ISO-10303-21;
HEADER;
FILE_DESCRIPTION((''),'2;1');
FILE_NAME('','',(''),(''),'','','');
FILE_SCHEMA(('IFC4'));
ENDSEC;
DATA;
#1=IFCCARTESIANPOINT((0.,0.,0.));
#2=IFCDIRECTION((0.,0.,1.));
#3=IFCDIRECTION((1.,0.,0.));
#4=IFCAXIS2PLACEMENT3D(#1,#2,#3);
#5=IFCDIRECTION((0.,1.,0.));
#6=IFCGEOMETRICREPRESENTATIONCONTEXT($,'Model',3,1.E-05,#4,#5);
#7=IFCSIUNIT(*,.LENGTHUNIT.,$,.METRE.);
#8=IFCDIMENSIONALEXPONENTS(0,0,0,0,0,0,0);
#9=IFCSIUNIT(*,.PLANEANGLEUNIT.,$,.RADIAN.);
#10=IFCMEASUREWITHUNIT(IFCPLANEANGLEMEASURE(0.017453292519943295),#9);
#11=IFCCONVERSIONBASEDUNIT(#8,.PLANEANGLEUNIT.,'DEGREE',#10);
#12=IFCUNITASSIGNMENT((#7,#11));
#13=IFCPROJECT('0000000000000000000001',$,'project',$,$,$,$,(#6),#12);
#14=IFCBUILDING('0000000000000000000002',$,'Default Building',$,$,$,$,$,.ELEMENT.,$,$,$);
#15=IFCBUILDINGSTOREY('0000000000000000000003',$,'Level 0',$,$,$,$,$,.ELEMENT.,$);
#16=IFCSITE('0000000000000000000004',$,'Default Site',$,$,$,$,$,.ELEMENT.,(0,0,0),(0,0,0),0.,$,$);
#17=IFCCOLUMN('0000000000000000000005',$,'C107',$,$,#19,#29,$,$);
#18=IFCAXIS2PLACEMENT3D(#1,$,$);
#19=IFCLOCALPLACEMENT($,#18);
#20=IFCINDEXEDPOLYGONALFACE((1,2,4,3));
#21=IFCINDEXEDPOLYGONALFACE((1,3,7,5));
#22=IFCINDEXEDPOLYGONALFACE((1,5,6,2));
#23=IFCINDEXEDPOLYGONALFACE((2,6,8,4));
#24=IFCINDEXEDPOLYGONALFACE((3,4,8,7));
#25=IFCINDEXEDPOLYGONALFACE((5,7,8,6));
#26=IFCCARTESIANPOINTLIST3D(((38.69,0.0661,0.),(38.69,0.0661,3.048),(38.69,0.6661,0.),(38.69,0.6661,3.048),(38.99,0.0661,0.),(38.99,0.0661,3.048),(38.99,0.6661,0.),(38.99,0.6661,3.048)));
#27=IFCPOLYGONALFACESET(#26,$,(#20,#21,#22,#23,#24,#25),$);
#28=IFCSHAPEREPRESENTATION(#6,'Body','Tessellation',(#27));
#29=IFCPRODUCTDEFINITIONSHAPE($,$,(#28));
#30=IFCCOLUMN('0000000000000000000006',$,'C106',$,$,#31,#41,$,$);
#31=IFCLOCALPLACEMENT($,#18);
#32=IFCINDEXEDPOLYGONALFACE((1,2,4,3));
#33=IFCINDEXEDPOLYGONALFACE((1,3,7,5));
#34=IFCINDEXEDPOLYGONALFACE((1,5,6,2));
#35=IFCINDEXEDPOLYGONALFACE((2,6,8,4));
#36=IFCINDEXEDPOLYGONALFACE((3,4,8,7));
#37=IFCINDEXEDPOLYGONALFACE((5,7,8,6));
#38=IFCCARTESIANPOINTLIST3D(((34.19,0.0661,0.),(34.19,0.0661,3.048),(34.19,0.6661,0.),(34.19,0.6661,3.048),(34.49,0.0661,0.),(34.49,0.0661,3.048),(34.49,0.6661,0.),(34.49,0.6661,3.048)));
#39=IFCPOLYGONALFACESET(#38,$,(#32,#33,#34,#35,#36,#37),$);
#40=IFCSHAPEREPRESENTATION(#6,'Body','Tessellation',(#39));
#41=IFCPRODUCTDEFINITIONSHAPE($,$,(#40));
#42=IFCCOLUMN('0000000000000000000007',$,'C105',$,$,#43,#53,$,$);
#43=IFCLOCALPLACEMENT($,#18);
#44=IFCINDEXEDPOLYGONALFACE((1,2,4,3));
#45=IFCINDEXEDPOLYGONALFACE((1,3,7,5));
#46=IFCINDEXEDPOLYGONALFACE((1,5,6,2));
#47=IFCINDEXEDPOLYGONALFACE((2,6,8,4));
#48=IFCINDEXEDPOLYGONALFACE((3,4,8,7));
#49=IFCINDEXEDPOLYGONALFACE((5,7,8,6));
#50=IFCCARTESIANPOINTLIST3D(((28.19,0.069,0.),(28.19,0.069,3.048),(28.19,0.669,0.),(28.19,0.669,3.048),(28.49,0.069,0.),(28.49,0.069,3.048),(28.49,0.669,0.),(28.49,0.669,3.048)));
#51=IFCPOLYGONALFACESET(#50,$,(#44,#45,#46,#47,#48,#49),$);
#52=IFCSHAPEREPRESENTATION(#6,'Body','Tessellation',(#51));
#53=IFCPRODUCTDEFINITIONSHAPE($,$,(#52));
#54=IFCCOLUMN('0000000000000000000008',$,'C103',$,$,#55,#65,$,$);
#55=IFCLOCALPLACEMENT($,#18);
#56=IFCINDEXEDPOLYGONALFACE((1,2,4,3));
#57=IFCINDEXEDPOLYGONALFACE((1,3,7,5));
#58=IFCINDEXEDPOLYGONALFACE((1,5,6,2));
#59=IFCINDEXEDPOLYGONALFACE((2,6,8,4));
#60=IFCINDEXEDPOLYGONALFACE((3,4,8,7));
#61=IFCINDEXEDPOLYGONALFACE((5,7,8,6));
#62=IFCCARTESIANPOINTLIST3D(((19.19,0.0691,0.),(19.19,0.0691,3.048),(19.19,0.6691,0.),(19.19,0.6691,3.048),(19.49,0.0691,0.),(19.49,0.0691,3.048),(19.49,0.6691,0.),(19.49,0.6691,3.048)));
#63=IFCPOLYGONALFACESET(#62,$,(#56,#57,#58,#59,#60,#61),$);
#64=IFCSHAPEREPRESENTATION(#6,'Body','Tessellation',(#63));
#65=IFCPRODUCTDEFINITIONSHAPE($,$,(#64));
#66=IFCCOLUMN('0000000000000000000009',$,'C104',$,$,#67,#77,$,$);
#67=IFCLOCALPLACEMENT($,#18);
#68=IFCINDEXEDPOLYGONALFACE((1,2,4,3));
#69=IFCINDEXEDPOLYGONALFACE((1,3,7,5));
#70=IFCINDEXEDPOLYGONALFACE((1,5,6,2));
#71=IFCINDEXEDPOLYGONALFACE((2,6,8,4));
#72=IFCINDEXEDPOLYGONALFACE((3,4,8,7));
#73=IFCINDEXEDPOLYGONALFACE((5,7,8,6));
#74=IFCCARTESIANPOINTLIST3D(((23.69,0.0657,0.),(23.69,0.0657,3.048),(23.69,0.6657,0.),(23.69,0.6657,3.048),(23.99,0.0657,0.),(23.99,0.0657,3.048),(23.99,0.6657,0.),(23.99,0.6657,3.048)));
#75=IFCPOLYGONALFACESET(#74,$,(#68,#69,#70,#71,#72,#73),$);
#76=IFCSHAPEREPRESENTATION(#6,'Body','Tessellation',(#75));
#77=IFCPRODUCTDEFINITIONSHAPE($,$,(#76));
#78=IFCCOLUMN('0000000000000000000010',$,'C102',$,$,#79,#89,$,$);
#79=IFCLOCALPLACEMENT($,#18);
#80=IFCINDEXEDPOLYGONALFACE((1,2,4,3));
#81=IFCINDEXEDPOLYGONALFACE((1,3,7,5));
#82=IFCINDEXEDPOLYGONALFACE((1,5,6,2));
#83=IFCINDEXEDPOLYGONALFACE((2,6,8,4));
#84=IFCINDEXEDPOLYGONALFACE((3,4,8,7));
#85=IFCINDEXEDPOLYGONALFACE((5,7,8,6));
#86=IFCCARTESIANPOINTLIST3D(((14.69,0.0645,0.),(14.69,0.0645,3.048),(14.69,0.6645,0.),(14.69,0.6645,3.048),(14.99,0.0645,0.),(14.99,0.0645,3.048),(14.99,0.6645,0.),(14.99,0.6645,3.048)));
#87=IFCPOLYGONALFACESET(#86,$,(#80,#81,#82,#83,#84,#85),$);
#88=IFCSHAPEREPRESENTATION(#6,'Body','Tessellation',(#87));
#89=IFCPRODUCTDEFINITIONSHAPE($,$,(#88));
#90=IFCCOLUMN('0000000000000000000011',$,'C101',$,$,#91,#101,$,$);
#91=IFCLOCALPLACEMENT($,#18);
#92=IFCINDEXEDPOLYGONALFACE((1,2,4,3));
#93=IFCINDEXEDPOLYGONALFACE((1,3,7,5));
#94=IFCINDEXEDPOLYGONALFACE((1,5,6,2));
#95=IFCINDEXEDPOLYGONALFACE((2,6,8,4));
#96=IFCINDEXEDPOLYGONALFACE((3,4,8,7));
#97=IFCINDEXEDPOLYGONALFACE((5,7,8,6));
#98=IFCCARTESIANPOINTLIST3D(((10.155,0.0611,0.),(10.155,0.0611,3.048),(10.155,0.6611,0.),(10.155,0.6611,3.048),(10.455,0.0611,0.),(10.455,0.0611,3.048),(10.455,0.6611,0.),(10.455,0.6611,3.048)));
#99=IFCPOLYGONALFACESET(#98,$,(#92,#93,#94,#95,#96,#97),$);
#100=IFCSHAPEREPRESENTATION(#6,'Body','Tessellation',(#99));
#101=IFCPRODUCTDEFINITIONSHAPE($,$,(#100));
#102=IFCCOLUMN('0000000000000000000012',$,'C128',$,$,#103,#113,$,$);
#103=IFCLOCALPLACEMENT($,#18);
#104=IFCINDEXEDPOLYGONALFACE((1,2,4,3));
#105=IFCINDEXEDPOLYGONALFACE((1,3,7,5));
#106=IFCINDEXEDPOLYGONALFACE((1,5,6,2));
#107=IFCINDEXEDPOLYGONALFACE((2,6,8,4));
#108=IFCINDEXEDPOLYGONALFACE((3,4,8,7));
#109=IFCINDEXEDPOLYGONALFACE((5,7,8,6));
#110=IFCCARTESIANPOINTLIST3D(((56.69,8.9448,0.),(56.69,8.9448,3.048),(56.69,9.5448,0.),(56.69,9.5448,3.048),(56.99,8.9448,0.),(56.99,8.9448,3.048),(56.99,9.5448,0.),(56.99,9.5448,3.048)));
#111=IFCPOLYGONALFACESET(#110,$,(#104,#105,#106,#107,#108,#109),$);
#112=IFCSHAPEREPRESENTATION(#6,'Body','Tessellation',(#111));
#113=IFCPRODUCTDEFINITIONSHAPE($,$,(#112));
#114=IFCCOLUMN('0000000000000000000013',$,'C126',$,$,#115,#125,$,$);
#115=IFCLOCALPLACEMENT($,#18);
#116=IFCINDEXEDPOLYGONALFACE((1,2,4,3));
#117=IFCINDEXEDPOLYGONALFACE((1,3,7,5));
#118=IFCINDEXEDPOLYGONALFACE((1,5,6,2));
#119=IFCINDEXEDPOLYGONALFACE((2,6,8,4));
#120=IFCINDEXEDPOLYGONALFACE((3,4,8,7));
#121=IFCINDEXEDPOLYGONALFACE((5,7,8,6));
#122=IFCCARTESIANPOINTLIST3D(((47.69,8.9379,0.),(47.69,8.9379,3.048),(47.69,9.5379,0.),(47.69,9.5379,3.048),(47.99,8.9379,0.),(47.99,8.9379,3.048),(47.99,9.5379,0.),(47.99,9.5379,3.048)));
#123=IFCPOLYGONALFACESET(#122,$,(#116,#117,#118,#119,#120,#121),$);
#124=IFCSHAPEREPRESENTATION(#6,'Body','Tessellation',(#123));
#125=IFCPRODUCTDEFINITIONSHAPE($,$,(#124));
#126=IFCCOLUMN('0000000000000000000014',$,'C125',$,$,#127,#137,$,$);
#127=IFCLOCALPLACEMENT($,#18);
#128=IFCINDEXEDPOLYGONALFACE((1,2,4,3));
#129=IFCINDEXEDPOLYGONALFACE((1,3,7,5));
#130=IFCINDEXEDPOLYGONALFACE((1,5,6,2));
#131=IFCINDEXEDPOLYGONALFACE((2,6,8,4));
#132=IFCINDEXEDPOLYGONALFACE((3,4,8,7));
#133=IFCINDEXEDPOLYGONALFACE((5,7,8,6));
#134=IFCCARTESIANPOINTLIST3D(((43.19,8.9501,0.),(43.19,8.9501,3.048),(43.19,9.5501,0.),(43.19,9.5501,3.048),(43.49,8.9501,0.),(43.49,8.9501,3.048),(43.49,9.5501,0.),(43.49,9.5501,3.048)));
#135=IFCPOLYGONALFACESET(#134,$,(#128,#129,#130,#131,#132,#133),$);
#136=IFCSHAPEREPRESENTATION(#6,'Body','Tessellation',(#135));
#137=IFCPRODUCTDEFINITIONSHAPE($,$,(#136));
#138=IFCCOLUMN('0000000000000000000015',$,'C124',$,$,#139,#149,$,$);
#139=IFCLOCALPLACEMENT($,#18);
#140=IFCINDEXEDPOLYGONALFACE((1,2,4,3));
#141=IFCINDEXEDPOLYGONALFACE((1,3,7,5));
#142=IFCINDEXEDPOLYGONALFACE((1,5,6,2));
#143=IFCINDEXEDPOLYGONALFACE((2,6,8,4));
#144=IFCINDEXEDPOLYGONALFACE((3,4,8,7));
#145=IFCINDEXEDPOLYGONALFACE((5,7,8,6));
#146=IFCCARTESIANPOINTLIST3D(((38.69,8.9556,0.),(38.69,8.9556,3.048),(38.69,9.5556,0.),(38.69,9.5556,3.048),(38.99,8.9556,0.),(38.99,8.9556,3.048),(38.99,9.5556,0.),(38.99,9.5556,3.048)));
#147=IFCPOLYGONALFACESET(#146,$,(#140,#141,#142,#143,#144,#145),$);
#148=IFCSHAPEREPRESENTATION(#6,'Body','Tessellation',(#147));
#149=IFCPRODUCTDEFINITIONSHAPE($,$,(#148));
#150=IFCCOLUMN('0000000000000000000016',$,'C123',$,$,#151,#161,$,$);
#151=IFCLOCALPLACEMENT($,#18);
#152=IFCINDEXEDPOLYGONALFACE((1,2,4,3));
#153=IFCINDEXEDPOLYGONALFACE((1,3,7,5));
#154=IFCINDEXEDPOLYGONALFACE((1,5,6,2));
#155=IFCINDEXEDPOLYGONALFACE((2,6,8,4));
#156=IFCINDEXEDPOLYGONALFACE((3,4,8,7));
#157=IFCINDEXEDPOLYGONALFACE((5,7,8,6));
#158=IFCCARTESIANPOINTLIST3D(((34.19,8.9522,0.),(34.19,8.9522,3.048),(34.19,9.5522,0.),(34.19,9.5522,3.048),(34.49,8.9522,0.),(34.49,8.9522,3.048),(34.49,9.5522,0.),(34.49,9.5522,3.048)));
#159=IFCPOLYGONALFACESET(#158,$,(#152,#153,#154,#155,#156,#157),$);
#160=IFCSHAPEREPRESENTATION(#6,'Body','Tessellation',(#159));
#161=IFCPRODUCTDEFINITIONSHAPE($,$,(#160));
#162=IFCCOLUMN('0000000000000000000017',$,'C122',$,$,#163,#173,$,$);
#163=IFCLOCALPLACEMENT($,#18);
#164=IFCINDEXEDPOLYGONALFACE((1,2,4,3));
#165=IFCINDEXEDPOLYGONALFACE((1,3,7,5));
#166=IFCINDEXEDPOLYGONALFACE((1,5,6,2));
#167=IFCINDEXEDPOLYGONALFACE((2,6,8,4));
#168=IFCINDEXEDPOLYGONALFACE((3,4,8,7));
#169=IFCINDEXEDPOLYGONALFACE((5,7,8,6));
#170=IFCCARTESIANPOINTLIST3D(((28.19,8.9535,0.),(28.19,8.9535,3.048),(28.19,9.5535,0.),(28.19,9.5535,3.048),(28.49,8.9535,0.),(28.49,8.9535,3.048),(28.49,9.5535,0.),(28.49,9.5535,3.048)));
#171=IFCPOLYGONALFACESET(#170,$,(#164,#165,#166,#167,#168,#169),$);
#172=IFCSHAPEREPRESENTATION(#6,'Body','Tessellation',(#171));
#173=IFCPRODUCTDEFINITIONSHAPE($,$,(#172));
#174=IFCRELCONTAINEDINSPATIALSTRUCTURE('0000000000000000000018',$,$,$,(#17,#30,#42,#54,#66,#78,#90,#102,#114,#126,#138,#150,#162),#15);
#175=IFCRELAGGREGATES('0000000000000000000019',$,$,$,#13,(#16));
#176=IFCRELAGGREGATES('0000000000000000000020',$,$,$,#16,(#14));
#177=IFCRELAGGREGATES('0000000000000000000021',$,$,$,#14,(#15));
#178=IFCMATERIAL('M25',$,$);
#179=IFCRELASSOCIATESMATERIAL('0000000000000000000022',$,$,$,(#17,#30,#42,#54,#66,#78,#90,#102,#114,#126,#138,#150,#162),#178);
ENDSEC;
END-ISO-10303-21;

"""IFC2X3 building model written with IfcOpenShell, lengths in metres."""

from ifc_helpers import new_model, entity, si_unit, converted_unit, direction, frame, frame_2d, origin_with_axes, place, context, project, spatial, rectangle, extrude, material, element, save


model = new_model("IFC2X3")

# Units and contexts
model_context = context("Model", 3, precision=1e-05, world=origin_with_axes(), true_north=direction((0.0, 1.0, 0.0)))
ifc_project = project(units=[si_unit("LENGTHUNIT", "METRE"), converted_unit("PLANEANGLEUNIT", "DEGREE", entity("IfcPlaneAngleMeasure", 0.017453292519943295), si_unit("PLANEANGLEUNIT", "RADIAN"), dimensions=[0, 0, 0, 0, 0, 0, 0])], contexts=[model_context])

# Site, building, storey
site = spatial("IfcSite", under=ifc_project, Name="Default Site", CompositionType="ELEMENT", RefLatitude=(0, 0, 0), RefLongitude=(0, 0, 0), RefElevation=0.0)
building = spatial("IfcBuilding", under=site, Name="Default Building", CompositionType="ELEMENT")
storey = spatial("IfcBuildingStorey", under=building, Name="Level 0", CompositionType="ELEMENT")

# Columns
ifc_material = material(Name="M25")
placement = place(None, origin_with_axes())
element("IfcColumn", 1, at=placement, inside=storey, material=ifc_material, Name="C107", context=model_context, shape_type="SweptSolid", body=[
    extrude(rectangle(XDim=0.3, YDim=0.6, at=frame_2d((0.0, 0.0), x_axis=(1.0, 0.0, 0.0))), frame((38.84, 0.3661, 0.0), z_axis=(0.0, 0.0, 1.0), x_axis=(1.0, 0.0, 0.0)), (0.0, 0.0, 1.0), 3.048),
])
element("IfcColumn", 2, at=placement, inside=storey, material=ifc_material, Name="C106", context=model_context, shape_type="SweptSolid", body=[
    extrude(rectangle(XDim=0.3, YDim=0.6, at=frame_2d((0.0, 0.0), x_axis=(1.0, 0.0, 0.0))), frame((34.34, 0.3661, 0.0), z_axis=(0.0, 0.0, 1.0), x_axis=(1.0, 0.0, 0.0)), (0.0, 0.0, 1.0), 3.048),
])
element("IfcColumn", 3, at=placement, inside=storey, material=ifc_material, Name="C105", context=model_context, shape_type="SweptSolid", body=[
    extrude(rectangle(XDim=0.3, YDim=0.6, at=frame_2d((0.0, 0.0), x_axis=(1.0, 0.0, 0.0))), frame((28.34, 0.369, 0.0), z_axis=(0.0, 0.0, 1.0), x_axis=(1.0, 0.0, 0.0)), (0.0, 0.0, 1.0), 3.048),
])
element("IfcColumn", 4, at=placement, inside=storey, material=ifc_material, Name="C103", context=model_context, shape_type="SweptSolid", body=[
    extrude(rectangle(XDim=0.3, YDim=0.6, at=frame_2d((0.0, 0.0), x_axis=(1.0, 0.0, 0.0))), frame((19.34, 0.3691, 0.0), z_axis=(0.0, 0.0, 1.0), x_axis=(1.0, 0.0, 0.0)), (0.0, 0.0, 1.0), 3.048),
])
element("IfcColumn", 5, at=placement, inside=storey, material=ifc_material, Name="C104", context=model_context, shape_type="SweptSolid", body=[
    extrude(rectangle(XDim=0.3, YDim=0.6, at=frame_2d((0.0, 0.0), x_axis=(1.0, 0.0, 0.0))), frame((23.84, 0.3657, 0.0), z_axis=(0.0, 0.0, 1.0), x_axis=(1.0, 0.0, 0.0)), (0.0, 0.0, 1.0), 3.048),
])
element("IfcColumn", 6, at=placement, inside=storey, material=ifc_material, Name="C102", context=model_context, shape_type="SweptSolid", body=[
    extrude(rectangle(XDim=0.3, YDim=0.6, at=frame_2d((0.0, 0.0), x_axis=(1.0, 0.0, 0.0))), frame((14.84, 0.3645, 0.0), z_axis=(0.0, 0.0, 1.0), x_axis=(1.0, 0.0, 0.0)), (0.0, 0.0, 1.0), 3.048),
])
element("IfcColumn", 7, at=placement, inside=storey, material=ifc_material, Name="C101", context=model_context, shape_type="SweptSolid", body=[
    extrude(rectangle(XDim=0.3, YDim=0.6, at=frame_2d((0.0, 0.0), x_axis=(1.0, 0.0, 0.0))), frame((10.305, 0.3611, 0.0), z_axis=(0.0, 0.0, 1.0), x_axis=(1.0, 0.0, 0.0)), (0.0, 0.0, 1.0), 3.048),
])
element("IfcColumn", 8, at=placement, inside=storey, material=ifc_material, Name="C128", context=model_context, shape_type="SweptSolid", body=[
    extrude(rectangle(XDim=0.3, YDim=0.6, at=frame_2d((0.0, 0.0), x_axis=(1.0, 0.0, 0.0))), frame((56.84, 9.2448, 0.0), z_axis=(0.0, 0.0, 1.0), x_axis=(1.0, 0.0, 0.0)), (0.0, 0.0, 1.0), 3.048),
])
element("IfcColumn", 9, at=placement, inside=storey, material=ifc_material, Name="C126", context=model_context, shape_type="SweptSolid", body=[
    extrude(rectangle(XDim=0.3, YDim=0.6, at=frame_2d((0.0, 0.0), x_axis=(1.0, 0.0, 0.0))), frame((47.84, 9.2379, 0.0), z_axis=(0.0, 0.0, 1.0), x_axis=(1.0, 0.0, 0.0)), (0.0, 0.0, 1.0), 3.048),
])
element("IfcColumn", 10, at=placement, inside=storey, material=ifc_material, Name="C125", context=model_context, shape_type="SweptSolid", body=[
    extrude(rectangle(XDim=0.3, YDim=0.6, at=frame_2d((0.0, 0.0), x_axis=(1.0, 0.0, 0.0))), frame((43.34, 9.2501, 0.0), z_axis=(0.0, 0.0, 1.0), x_axis=(1.0, 0.0, 0.0)), (0.0, 0.0, 1.0), 3.048),
])
element("IfcColumn", 11, at=placement, inside=storey, material=ifc_material, Name="C124", context=model_context, shape_type="SweptSolid", body=[
    extrude(rectangle(XDim=0.3, YDim=0.6, at=frame_2d((0.0, 0.0), x_axis=(1.0, 0.0, 0.0))), frame((38.84, 9.2556, 0.0), z_axis=(0.0, 0.0, 1.0), x_axis=(1.0, 0.0, 0.0)), (0.0, 0.0, 1.0), 3.048),
])
element("IfcColumn", 12, at=placement, inside=storey, material=ifc_material, Name="C123", context=model_context, shape_type="SweptSolid", body=[
    extrude(rectangle(XDim=0.3, YDim=0.6, at=frame_2d((0.0, 0.0), x_axis=(1.0, 0.0, 0.0))), frame((34.34, 9.2522, 0.0), z_axis=(0.0, 0.0, 1.0), x_axis=(1.0, 0.0, 0.0)), (0.0, 0.0, 1.0), 3.048),
])
element("IfcColumn", 13, at=placement, inside=storey, material=ifc_material, Name="C122", context=model_context, shape_type="SweptSolid", body=[
    extrude(rectangle(XDim=0.3, YDim=0.6, at=frame_2d((0.0, 0.0), x_axis=(1.0, 0.0, 0.0))), frame((28.34, 9.2535, 0.0), z_axis=(0.0, 0.0, 1.0), x_axis=(1.0, 0.0, 0.0)), (0.0, 0.0, 1.0), 3.048),
])

save(model, "model.ifc")
